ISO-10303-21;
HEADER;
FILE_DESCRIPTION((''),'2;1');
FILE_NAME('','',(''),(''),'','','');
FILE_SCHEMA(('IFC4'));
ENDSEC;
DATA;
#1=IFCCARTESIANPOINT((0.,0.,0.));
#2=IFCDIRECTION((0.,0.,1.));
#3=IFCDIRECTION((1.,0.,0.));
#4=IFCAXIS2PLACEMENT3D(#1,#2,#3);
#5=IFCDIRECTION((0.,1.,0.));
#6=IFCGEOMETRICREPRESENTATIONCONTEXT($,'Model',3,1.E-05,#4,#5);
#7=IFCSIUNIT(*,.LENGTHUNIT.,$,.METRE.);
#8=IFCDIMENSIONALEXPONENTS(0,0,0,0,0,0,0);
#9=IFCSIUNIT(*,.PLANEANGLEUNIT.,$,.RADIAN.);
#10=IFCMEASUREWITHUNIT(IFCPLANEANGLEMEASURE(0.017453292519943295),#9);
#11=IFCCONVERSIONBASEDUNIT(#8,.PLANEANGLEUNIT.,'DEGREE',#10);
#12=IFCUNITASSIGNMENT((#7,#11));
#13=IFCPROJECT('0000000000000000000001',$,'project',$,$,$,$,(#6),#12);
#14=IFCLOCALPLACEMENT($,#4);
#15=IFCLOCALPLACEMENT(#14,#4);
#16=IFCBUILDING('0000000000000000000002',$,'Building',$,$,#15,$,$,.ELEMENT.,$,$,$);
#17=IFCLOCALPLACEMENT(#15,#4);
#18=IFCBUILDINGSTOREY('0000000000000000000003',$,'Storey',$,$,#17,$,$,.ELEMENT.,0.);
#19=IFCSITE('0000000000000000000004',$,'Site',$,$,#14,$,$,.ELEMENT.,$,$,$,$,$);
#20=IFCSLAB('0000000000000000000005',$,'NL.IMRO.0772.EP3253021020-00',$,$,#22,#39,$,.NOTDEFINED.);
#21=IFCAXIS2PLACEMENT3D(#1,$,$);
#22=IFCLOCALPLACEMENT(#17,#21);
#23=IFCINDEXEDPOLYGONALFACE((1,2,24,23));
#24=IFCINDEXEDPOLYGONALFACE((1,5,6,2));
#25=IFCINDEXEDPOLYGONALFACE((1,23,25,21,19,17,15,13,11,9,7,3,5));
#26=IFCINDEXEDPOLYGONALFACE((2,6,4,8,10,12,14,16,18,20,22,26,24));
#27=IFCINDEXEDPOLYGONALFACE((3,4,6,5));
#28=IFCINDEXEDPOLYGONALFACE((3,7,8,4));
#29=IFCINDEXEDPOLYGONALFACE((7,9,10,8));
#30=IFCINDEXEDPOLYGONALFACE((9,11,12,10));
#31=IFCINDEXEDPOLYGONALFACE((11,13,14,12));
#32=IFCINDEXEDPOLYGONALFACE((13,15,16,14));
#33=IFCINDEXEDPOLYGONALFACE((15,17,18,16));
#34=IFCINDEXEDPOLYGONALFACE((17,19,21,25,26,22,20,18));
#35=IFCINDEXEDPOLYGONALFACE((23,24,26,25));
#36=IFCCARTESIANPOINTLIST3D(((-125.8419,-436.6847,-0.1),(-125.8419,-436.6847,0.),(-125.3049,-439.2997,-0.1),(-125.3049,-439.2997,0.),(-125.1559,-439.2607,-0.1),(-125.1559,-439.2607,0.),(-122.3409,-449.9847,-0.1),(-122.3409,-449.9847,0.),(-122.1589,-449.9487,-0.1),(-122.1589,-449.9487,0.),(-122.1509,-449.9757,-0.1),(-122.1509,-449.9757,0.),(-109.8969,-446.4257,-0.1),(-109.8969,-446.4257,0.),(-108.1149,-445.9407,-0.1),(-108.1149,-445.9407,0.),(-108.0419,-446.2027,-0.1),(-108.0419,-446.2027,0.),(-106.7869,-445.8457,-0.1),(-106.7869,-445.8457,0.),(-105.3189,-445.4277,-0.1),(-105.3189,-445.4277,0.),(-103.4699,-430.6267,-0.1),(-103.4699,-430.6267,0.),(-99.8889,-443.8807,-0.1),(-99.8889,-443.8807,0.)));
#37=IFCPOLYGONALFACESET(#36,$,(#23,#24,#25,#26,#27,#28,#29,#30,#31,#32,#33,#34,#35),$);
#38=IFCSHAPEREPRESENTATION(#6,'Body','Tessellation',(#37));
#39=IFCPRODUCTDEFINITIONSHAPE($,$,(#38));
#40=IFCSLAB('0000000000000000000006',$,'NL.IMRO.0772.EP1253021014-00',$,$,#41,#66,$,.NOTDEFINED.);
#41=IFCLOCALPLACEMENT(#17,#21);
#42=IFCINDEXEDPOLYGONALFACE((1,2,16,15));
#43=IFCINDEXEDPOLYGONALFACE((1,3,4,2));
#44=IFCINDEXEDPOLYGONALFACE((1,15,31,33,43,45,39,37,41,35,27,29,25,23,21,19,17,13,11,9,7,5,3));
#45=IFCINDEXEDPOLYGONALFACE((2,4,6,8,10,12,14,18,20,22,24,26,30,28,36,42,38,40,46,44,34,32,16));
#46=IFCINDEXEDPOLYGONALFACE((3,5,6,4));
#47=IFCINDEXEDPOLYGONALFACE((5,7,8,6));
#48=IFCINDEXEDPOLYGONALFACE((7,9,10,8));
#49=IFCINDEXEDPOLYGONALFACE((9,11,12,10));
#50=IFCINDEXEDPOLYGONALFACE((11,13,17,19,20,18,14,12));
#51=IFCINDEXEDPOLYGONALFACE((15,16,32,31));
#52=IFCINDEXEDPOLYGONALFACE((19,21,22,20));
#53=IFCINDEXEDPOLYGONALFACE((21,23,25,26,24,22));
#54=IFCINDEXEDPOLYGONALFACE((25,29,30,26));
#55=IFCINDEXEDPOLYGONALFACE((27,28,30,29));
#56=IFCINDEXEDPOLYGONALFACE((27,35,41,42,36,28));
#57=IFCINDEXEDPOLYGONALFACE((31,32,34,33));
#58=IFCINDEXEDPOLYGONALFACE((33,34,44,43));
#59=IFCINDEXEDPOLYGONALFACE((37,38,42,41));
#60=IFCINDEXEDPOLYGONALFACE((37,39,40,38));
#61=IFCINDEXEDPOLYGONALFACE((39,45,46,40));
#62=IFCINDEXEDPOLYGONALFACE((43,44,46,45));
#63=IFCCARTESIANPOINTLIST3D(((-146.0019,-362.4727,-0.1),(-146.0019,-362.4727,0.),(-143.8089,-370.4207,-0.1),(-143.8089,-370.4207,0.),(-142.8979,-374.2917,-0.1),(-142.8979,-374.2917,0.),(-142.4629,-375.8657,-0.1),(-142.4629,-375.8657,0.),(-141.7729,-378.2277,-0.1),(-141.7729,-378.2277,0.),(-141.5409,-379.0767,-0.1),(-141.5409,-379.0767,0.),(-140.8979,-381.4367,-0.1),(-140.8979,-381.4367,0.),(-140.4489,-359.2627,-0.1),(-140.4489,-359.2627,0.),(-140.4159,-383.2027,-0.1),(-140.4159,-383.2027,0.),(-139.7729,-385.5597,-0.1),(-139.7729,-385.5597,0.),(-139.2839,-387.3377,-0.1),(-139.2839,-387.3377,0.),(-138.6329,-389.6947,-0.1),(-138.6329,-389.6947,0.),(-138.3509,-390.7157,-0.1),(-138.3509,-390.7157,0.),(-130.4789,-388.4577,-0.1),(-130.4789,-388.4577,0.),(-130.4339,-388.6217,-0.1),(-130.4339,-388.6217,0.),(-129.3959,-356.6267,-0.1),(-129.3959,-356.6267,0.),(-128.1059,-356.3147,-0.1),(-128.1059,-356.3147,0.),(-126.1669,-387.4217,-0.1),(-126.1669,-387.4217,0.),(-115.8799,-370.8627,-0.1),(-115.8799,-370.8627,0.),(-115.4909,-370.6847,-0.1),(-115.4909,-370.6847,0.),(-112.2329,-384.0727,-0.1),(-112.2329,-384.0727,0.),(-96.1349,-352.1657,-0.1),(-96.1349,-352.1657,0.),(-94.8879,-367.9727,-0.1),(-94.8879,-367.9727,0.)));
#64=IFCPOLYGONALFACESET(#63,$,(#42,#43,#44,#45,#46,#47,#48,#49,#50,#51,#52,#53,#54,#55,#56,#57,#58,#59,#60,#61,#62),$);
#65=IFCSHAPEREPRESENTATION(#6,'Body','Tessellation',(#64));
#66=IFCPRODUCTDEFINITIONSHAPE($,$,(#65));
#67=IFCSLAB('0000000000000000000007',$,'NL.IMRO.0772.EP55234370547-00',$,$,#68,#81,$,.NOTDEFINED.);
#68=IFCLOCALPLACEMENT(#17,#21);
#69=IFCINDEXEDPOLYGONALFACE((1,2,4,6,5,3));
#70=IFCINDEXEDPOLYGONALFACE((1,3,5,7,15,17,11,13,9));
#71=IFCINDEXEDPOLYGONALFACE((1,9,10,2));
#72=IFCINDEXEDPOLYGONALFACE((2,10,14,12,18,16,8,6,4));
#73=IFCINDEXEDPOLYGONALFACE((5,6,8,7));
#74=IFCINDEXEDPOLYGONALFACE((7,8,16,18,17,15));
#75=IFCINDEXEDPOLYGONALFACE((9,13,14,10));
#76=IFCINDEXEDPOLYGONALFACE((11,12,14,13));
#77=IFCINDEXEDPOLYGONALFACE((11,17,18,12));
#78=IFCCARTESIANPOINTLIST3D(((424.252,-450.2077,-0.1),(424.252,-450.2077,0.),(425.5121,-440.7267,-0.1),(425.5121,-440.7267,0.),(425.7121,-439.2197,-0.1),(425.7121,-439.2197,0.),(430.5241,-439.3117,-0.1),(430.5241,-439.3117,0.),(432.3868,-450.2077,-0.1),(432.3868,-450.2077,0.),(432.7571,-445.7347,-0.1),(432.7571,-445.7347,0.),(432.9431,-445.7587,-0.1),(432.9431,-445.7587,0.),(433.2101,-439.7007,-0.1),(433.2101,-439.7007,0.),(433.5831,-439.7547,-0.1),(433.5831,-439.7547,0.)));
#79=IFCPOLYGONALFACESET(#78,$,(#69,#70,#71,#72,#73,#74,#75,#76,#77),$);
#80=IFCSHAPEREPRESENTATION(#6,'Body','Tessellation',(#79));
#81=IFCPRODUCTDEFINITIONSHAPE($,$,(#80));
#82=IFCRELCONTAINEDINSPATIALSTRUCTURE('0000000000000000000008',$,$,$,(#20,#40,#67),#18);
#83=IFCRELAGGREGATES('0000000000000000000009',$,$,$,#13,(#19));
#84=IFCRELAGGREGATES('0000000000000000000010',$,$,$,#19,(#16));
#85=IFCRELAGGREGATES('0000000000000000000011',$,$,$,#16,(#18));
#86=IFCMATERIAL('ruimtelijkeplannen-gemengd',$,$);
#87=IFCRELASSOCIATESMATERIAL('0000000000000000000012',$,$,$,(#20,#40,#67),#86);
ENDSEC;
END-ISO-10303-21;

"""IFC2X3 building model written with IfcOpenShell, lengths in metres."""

from ifc_helpers import new_model, entity, si_unit, converted_unit, direction, frame, origin_with_axes, place, context, project, spatial, polyline, outline, extrude, material, element, save


model = new_model("IFC2X3")

# Units and contexts
model_context = context("Model", 3, precision=1e-05, world=origin_with_axes(), true_north=direction((0.0, 1.0, 0.0)))
ifc_project = project(units=[si_unit("LENGTHUNIT", "METRE"), converted_unit("PLANEANGLEUNIT", "DEGREE", entity("IfcPlaneAngleMeasure", 0.017453292519943295), si_unit("PLANEANGLEUNIT", "RADIAN"), dimensions=[0, 0, 0, 0, 0, 0, 0])], contexts=[model_context])

# Site, building, storey
site_placement = place(None, origin_with_axes())
site = spatial("IfcSite", under=ifc_project, at=site_placement, Name="Site", CompositionType="ELEMENT")
building_placement = place(site_placement, origin_with_axes())
building = spatial("IfcBuilding", under=site, at=building_placement, Name="Building", CompositionType="ELEMENT")
storey_placement = place(building_placement, origin_with_axes())
storey = spatial("IfcBuildingStorey", under=building, at=storey_placement, Name="Storey", CompositionType="ELEMENT", Elevation=0.0)

# Slabs
ifc_material_1 = material(Name="ruimtelijkeplannen-gemengd")
slab_1_placement = place(storey_placement, frame((0.0, 0.0, -0.1), z_axis=(0.0, 0.0, 1.0), x_axis=(1.0, 0.0, 0.0)))
element("IfcSlab", 1, at=slab_1_placement, inside=storey, material=ifc_material_1, Name="NL.IMRO.0772.EP3253021020-00", PredefinedType="NOTDEFINED", context=model_context, shape_type="SweptSolid", body=[
    extrude(outline(polyline([(-103.4699, -430.6267), (-99.8889, -443.8807), (-105.3189, -445.4277), (-106.7869, -445.8457), (-108.0419, -446.2027), (-108.1149, -445.9407), (-109.8969, -446.4257), (-122.1509, -449.9757), (-122.1589, -449.9487), (-122.3409, -449.9847), (-125.3049, -439.2997), (-125.1559, -439.2607), (-125.8419, -436.6847), (-103.4699, -430.6267)])), origin_with_axes(), (0.0, 0.0, 1.0), 0.1),
])
slab_2_placement = place(storey_placement, frame((0.0, 0.0, -0.1), z_axis=(0.0, 0.0, 1.0), x_axis=(1.0, 0.0, 0.0)))
element("IfcSlab", 2, at=slab_2_placement, inside=storey, material=ifc_material_1, Name="NL.IMRO.0772.EP1253021014-00", PredefinedType="NOTDEFINED", context=model_context, shape_type="SweptSolid", body=[
    extrude(outline(polyline([(-146.0019, -362.4727), (-140.4489, -359.2627), (-129.3959, -356.6267), (-128.1059, -356.3147), (-96.1349, -352.1657), (-94.8879, -367.9727), (-115.4909, -370.6847), (-115.8799, -370.8627), (-112.2329, -384.0727), (-126.1669, -387.4217), (-130.4789, -388.4577), (-130.4339, -388.6217), (-138.3509, -390.7157), (-138.6329, -389.6947), (-139.2839, -387.3377), (-139.7729, -385.5597), (-140.4159, -383.2027), (-140.8979, -381.4367), (-141.5409, -379.0767), (-141.7729, -378.2277), (-142.4629, -375.8657), (-142.8979, -374.2917), (-143.8089, -370.4207), (-146.0019, -362.4727)])), origin_with_axes(), (0.0, 0.0, 1.0), 0.1),
])
slab_3_placement = place(storey_placement, frame((0.0, 0.0, -0.1), z_axis=(0.0, 0.0, 1.0), x_axis=(1.0, 0.0, 0.0)))
element("IfcSlab", 3, at=slab_3_placement, inside=storey, material=ifc_material_1, Name="NL.IMRO.0772.EP55234370547-00", PredefinedType="NOTDEFINED", context=model_context, shape_type="SweptSolid", body=[
    extrude(outline(polyline([(425.5121, -440.7267), (425.7121, -439.2197), (430.5241, -439.3117), (433.2101, -439.7007), (433.5831, -439.7547), (432.7571, -445.7347), (432.9431, -445.7587), (432.3868, -450.2077), (424.252, -450.2077), (425.5121, -440.7267)])), origin_with_axes(), (0.0, 0.0, 1.0), 0.1),
])

save(model, "model.ifc")
